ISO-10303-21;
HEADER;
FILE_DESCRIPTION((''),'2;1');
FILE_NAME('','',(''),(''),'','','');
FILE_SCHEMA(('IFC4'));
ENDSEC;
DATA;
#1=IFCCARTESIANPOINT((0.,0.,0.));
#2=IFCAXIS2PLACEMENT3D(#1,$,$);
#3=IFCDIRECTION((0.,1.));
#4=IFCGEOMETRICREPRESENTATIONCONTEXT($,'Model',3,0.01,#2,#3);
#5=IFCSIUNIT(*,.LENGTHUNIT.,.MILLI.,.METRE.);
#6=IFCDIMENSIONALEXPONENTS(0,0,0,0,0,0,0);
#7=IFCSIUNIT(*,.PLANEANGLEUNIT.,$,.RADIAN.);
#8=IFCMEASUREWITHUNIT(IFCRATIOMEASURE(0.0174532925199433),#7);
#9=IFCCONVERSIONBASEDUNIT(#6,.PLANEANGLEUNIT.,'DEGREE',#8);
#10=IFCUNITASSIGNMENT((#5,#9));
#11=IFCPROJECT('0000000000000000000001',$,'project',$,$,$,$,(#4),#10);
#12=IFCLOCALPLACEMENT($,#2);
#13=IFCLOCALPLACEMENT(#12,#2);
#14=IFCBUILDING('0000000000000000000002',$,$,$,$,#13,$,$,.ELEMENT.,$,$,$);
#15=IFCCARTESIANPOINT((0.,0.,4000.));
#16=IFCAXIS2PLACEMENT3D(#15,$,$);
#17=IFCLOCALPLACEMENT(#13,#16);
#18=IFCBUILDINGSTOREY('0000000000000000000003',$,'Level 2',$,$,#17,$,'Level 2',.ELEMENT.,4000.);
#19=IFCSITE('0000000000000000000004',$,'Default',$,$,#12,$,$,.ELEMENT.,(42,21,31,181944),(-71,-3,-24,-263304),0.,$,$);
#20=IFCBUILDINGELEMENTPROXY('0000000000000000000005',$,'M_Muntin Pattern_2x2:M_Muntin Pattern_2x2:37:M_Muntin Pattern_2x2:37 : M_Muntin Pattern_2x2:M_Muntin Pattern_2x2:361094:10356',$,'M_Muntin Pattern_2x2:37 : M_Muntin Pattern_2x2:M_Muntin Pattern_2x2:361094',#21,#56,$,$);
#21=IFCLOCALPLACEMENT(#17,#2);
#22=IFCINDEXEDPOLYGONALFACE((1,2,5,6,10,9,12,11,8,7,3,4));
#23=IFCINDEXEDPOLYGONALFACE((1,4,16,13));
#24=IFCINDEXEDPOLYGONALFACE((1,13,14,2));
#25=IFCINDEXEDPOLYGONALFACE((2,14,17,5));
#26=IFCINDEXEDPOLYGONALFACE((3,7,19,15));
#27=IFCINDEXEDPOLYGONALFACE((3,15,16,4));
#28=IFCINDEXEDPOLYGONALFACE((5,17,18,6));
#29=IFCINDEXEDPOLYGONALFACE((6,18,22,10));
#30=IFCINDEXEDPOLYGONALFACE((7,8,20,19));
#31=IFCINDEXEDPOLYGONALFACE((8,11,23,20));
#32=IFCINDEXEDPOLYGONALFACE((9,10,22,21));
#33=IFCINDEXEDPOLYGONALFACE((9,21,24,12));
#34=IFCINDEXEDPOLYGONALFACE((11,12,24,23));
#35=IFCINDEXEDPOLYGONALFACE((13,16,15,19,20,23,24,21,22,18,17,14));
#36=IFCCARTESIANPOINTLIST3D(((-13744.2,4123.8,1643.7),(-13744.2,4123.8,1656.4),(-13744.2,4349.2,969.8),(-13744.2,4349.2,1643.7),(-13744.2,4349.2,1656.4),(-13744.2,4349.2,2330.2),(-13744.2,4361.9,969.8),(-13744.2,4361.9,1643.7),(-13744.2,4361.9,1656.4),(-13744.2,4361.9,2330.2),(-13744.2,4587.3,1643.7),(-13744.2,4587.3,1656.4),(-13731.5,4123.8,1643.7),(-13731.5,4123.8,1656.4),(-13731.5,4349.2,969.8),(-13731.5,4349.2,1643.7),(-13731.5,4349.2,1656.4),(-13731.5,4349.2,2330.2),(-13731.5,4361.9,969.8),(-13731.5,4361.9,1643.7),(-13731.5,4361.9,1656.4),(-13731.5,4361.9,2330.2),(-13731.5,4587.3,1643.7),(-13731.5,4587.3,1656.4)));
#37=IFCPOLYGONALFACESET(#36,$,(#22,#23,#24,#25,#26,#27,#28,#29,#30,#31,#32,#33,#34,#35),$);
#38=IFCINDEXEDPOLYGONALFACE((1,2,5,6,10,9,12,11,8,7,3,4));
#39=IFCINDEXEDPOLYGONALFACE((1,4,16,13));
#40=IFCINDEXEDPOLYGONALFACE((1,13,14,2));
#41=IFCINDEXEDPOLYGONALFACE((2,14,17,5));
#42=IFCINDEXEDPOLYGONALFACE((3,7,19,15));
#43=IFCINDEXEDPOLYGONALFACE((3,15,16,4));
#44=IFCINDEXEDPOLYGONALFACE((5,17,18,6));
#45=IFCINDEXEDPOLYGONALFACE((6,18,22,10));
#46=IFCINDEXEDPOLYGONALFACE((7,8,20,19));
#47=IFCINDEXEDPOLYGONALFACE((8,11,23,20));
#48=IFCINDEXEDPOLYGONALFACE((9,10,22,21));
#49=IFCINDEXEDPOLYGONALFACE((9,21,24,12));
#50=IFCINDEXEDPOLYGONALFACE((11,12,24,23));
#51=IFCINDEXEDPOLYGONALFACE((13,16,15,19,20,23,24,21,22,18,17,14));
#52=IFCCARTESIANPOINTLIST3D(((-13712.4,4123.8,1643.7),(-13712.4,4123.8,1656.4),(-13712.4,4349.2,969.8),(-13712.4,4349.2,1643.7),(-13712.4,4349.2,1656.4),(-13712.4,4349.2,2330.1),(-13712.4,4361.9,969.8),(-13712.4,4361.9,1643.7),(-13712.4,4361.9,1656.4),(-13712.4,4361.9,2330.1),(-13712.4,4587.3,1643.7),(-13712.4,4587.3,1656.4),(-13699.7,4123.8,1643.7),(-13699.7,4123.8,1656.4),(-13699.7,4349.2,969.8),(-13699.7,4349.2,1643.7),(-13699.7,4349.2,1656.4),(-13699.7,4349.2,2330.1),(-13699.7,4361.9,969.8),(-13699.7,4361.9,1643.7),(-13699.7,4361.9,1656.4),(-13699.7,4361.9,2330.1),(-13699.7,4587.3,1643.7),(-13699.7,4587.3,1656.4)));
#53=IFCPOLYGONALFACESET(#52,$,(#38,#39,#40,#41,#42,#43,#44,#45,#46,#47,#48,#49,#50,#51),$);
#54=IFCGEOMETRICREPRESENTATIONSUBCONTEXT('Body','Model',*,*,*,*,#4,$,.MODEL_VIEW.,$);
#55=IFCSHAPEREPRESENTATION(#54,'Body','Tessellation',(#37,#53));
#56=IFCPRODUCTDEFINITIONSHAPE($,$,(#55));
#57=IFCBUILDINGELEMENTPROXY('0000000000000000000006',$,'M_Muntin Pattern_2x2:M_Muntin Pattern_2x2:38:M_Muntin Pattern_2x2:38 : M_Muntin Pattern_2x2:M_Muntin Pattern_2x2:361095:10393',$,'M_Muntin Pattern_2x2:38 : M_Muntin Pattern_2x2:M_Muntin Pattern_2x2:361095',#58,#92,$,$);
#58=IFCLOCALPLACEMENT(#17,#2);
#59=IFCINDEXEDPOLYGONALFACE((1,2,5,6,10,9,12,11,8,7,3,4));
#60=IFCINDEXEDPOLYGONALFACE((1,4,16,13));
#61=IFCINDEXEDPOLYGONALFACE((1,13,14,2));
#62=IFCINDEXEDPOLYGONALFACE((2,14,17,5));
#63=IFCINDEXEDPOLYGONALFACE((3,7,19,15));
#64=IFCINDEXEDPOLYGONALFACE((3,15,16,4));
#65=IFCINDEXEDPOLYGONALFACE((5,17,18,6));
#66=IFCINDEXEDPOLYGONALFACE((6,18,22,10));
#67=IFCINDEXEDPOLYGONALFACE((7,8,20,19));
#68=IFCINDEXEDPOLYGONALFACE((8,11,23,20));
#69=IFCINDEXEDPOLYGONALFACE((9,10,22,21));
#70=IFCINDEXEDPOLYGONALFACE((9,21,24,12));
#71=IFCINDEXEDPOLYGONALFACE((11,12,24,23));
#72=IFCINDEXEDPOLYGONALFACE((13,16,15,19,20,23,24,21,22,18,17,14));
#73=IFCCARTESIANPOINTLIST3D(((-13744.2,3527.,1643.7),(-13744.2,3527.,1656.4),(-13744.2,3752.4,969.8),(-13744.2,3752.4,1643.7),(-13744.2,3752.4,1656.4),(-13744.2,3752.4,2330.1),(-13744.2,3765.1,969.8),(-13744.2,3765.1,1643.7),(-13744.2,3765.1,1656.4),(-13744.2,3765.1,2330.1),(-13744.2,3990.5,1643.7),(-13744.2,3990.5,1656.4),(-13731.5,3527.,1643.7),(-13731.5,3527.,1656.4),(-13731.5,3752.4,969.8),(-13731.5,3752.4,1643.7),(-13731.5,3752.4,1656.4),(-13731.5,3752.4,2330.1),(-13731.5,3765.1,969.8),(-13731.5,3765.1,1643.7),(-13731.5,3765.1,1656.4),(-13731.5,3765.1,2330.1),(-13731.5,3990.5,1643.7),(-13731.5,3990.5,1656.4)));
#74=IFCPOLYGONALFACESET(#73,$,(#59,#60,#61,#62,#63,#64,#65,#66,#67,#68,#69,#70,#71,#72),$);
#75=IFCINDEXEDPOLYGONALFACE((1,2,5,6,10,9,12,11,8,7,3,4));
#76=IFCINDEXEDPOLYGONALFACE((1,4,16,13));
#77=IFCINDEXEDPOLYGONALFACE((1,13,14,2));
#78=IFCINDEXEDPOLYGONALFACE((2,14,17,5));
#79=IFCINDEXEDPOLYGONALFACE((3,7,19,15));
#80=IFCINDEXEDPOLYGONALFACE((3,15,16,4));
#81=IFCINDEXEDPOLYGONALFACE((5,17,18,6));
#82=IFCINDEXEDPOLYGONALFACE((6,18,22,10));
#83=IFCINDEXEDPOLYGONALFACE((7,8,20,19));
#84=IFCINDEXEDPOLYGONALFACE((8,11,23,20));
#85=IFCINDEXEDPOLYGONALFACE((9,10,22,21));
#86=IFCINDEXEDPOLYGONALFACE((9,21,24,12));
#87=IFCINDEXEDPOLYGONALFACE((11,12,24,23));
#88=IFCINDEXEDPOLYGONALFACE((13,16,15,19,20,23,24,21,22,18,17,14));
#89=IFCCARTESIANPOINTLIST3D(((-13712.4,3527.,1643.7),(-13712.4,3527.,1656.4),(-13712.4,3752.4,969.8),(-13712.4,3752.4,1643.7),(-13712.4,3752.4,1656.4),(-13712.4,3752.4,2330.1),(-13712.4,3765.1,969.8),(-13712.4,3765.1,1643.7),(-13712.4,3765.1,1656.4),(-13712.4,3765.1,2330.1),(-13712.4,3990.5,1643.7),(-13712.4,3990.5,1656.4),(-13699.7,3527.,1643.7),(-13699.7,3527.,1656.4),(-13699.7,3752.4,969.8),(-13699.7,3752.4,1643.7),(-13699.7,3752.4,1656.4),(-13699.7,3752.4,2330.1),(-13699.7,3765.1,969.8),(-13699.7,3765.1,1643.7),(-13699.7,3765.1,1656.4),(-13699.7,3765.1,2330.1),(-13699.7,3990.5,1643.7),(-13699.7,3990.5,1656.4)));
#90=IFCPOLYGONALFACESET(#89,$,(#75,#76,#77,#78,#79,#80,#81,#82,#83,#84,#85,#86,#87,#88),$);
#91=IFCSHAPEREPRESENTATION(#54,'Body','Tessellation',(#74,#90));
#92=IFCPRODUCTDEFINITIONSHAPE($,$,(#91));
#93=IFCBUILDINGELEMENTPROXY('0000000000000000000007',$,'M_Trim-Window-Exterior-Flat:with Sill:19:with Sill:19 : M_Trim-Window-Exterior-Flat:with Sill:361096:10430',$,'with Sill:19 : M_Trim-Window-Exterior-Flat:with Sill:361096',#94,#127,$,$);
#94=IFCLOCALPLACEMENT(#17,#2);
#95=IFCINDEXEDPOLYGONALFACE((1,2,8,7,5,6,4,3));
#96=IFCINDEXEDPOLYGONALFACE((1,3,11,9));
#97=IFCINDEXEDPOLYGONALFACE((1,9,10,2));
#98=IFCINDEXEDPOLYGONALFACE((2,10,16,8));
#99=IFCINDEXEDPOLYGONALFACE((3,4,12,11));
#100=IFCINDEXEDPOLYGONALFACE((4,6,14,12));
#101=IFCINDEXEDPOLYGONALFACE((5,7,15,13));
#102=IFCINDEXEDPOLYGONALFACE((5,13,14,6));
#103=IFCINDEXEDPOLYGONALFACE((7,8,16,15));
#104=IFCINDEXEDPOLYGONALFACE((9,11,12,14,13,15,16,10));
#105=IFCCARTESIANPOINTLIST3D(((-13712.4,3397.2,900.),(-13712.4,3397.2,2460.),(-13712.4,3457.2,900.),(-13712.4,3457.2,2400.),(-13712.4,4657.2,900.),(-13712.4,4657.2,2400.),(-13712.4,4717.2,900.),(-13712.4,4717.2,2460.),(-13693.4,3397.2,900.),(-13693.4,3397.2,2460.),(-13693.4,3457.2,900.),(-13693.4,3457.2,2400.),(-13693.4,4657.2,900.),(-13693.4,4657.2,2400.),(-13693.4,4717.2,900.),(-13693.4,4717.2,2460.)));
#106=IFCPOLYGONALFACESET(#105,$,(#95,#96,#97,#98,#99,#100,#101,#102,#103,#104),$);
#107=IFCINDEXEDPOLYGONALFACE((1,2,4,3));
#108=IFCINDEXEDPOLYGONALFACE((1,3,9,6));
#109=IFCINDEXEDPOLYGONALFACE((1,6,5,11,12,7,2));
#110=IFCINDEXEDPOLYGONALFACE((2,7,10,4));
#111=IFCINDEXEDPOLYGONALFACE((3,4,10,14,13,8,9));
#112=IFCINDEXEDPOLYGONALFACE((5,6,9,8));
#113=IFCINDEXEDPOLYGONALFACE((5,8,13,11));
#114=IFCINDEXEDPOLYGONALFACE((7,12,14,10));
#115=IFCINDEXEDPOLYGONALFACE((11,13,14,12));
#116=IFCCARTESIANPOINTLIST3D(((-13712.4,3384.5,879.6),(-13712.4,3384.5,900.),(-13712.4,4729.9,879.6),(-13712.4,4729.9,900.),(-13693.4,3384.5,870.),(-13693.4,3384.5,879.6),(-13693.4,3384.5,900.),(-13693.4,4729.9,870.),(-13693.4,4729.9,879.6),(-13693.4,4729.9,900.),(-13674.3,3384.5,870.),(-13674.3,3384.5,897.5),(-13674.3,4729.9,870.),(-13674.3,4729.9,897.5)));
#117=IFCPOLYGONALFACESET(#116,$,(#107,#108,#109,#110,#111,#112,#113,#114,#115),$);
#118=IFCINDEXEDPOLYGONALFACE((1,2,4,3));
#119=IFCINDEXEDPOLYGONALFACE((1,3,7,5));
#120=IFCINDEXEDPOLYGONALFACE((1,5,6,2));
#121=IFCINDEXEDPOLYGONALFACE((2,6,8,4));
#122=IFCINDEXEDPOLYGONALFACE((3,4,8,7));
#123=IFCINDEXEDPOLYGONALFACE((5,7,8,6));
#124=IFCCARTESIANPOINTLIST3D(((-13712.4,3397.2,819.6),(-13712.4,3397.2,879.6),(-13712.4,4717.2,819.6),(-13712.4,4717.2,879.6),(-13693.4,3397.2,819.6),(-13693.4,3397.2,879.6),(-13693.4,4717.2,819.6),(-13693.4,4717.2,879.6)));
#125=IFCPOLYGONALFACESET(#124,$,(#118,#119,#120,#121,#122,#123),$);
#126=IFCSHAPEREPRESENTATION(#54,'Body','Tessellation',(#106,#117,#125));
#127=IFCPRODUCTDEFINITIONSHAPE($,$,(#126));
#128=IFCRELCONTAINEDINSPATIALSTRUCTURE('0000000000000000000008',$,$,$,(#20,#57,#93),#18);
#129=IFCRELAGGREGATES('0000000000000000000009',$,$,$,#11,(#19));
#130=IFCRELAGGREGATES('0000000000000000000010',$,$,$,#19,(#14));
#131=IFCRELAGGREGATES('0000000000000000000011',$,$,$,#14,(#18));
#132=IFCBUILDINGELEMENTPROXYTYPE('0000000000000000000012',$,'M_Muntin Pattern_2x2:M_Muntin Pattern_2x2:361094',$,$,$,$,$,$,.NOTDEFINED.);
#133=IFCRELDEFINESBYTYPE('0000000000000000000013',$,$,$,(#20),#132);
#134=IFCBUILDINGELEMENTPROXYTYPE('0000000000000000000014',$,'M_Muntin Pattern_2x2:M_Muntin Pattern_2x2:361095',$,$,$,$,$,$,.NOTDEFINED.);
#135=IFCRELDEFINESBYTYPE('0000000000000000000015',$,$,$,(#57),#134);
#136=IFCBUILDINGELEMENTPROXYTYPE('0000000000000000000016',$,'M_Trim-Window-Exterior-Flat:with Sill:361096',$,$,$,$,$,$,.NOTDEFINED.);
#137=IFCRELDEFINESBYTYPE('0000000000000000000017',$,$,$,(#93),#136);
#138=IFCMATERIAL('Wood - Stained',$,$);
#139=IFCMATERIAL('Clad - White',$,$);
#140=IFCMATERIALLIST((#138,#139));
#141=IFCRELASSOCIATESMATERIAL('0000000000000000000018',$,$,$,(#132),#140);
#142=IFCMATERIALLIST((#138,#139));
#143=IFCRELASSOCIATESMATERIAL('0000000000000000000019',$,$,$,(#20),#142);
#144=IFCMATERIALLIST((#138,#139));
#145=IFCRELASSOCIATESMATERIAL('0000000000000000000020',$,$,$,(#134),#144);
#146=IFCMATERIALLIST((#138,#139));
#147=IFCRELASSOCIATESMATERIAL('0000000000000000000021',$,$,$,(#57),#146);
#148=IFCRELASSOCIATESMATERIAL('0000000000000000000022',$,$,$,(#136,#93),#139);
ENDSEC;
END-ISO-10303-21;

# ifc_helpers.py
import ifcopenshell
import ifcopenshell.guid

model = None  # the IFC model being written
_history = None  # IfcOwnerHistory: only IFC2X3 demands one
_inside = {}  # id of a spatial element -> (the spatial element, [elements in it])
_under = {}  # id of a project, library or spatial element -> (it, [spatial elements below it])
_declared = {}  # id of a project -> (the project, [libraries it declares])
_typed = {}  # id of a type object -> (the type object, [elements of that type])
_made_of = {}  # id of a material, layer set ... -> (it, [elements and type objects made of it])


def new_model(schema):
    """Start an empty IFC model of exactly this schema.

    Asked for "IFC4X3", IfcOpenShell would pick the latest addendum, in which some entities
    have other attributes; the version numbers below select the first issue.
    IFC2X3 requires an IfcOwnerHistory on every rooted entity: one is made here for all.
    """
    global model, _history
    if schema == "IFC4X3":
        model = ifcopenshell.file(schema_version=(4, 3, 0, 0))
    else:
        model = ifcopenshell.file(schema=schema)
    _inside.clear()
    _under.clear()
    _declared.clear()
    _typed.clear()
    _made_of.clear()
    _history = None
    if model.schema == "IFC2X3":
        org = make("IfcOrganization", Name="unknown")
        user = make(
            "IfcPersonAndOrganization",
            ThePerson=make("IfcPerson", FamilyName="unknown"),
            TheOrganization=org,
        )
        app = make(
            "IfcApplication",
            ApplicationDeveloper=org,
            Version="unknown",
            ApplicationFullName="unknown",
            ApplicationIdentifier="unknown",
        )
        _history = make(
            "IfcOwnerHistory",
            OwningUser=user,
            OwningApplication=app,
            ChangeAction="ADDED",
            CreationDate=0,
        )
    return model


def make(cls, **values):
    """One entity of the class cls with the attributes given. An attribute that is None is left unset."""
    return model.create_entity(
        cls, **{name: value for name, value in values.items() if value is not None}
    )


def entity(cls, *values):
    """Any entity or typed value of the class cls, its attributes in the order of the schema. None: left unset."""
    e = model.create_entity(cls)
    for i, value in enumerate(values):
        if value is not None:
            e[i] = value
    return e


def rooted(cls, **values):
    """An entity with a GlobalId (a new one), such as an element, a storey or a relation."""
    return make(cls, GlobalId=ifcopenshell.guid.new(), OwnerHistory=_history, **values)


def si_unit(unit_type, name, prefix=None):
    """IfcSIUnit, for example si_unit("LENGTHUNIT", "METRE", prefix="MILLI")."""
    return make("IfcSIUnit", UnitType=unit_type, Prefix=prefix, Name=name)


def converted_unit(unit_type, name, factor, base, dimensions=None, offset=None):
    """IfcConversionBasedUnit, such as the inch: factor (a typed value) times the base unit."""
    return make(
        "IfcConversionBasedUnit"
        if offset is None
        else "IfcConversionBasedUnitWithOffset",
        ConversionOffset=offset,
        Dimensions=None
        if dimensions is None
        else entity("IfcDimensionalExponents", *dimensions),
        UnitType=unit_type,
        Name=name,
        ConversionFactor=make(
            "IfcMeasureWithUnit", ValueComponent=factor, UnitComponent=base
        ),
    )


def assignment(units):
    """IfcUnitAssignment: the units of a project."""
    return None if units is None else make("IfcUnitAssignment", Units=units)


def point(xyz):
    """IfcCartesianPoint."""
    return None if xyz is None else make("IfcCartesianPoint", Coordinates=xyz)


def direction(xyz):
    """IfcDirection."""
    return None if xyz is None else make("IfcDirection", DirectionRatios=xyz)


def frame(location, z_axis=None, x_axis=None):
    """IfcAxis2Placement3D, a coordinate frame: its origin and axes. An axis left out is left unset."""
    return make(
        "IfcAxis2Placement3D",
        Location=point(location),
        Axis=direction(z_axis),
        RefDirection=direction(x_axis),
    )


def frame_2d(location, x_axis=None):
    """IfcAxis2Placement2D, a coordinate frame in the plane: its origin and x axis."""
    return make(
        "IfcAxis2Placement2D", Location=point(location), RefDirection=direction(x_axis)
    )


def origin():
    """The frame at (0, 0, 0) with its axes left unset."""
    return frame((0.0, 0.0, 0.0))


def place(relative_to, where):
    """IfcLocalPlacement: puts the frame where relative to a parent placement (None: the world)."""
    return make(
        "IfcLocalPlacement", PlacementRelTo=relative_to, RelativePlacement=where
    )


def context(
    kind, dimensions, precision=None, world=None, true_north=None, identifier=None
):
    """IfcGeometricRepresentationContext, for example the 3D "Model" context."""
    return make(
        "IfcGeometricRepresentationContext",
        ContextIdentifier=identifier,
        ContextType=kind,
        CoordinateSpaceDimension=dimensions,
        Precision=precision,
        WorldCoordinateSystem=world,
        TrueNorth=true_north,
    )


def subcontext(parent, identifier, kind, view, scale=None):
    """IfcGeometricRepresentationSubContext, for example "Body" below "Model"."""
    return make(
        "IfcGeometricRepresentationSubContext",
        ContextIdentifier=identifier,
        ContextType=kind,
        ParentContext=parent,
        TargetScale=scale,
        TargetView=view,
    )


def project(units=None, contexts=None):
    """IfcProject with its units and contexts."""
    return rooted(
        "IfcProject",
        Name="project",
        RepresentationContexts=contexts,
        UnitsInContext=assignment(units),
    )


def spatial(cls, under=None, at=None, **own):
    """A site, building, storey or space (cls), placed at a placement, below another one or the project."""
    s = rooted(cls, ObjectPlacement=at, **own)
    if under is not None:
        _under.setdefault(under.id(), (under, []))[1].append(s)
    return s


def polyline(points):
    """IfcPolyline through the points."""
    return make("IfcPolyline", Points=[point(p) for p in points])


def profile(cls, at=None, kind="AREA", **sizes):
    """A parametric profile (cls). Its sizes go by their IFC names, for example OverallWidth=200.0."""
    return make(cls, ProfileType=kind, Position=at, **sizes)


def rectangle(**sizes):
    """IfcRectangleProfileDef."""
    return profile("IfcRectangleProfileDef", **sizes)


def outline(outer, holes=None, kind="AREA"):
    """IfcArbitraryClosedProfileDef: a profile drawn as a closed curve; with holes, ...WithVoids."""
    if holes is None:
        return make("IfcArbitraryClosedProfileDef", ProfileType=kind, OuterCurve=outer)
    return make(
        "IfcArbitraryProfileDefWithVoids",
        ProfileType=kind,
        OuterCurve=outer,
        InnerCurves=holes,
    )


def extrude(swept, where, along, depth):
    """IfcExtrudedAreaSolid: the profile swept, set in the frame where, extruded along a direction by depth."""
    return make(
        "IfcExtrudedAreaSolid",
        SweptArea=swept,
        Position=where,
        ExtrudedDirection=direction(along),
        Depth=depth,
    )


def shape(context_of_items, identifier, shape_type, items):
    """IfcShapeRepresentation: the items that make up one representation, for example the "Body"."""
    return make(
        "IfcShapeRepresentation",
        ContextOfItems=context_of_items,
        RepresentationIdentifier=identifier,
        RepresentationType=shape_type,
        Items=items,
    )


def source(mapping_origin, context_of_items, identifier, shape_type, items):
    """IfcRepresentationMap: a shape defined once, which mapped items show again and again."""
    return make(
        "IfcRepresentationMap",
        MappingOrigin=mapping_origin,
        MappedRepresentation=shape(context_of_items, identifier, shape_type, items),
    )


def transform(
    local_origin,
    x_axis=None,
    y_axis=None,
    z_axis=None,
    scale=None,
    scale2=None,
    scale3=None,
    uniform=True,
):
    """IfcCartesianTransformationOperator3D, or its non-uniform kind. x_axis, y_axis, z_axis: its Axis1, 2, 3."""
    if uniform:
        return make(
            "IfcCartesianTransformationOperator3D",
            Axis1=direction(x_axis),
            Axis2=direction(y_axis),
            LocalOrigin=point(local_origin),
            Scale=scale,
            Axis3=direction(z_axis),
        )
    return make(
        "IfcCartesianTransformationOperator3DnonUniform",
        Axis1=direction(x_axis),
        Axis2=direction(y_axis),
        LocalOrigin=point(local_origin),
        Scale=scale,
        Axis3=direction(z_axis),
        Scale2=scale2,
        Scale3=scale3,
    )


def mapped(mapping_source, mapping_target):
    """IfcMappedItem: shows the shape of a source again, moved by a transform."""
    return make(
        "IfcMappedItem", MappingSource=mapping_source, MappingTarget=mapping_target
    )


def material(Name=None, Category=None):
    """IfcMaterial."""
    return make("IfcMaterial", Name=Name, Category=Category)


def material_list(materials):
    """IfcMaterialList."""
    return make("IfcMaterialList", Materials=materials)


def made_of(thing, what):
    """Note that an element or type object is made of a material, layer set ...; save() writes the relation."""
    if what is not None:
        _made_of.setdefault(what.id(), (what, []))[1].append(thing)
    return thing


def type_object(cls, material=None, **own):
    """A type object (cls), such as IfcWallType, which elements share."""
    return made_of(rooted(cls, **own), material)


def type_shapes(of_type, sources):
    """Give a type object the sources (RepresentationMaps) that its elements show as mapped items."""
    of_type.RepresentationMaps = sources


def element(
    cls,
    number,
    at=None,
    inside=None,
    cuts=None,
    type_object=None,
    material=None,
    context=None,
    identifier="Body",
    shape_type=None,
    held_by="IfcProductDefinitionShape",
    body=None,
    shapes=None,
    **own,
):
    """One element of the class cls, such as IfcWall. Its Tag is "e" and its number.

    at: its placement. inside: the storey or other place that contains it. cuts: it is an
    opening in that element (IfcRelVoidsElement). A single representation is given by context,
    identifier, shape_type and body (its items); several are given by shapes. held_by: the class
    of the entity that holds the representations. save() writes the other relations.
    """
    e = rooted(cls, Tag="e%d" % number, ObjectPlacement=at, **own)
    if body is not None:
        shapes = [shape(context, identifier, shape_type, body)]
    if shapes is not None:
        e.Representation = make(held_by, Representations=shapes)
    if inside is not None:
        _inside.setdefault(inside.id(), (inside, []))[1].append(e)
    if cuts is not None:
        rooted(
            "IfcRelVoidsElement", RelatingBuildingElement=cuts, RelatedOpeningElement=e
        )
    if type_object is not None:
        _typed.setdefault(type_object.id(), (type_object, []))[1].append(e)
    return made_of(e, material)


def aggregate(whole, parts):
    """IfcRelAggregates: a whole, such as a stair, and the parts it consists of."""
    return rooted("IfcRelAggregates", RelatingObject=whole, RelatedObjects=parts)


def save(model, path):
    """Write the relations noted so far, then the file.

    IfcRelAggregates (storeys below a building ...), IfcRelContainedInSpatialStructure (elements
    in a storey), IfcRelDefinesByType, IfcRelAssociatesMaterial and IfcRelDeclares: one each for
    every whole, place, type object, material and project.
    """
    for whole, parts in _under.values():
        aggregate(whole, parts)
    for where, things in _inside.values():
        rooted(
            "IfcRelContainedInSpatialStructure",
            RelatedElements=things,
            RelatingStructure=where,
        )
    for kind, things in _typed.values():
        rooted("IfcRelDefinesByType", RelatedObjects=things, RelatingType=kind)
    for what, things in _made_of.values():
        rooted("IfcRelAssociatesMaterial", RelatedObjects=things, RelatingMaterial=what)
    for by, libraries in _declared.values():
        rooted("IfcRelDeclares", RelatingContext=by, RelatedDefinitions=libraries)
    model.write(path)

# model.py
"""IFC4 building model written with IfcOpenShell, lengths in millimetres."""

from ifc_helpers import new_model, entity, si_unit, converted_unit, direction, frame, frame_2d, origin, place, context, subcontext, project, spatial, polyline, rectangle, outline, extrude, source, transform, mapped, material, material_list, type_object, type_shapes, element, save


model = new_model("IFC4")

# Units and contexts
model_context = context("Model", 3, precision=0.01, world=origin(), true_north=direction((0.0, 1.0)))
body_context = subcontext(model_context, "Body", "Model", "MODEL_VIEW")
ifc_project = project(units=[si_unit("LENGTHUNIT", "METRE", prefix="MILLI"), converted_unit("PLANEANGLEUNIT", "DEGREE", entity("IfcRatioMeasure", 0.0174532925199433), si_unit("PLANEANGLEUNIT", "RADIAN"), dimensions=[0, 0, 0, 0, 0, 0, 0])], contexts=[model_context])

# Site, building, storey
site_placement = place(None, origin())
site = spatial("IfcSite", under=ifc_project, at=site_placement, Name="Default", CompositionType="ELEMENT", RefLatitude=(42, 21, 31, 181944), RefLongitude=(-71, -3, -24, -263304), RefElevation=0.0)
building_placement = place(site_placement, origin())
building = spatial("IfcBuilding", under=site, at=building_placement, CompositionType="ELEMENT")
storey_placement = place(building_placement, frame((0.0, 0.0, 4000.0)))
storey = spatial("IfcBuildingStorey", under=building, at=storey_placement, Name="Level 2", LongName="Level 2", CompositionType="ELEMENT", Elevation=4000.0)

# Building element proxies
ifc_material_1 = material(Name="Wood - Stained")
ifc_material_2 = material(Name="Clad - White")
ifc_material_list_1 = material_list([ifc_material_1, ifc_material_2])
ifc_material_list_2 = material_list([ifc_material_1, ifc_material_2])
building_element_proxy_type_1 = type_object("IfcBuildingElementProxyType", Name="M_Muntin Pattern_2x2:M_Muntin Pattern_2x2:361094", PredefinedType="NOTDEFINED", material=ifc_material_list_2)
shared_shape_1 = source(origin(), body_context, "Body", "SweptSolid", [
    extrude(outline(polyline([(-6.4, -680.2), (6.3, -680.2), (6.3, -6.4), (231.7, -6.4), (231.7, 6.3), (6.3, 6.3), (6.3, 680.2), (-6.4, 680.2), (-6.4, 6.3), (-231.7, 6.3), (-231.7, -6.4), (-6.4, -6.4), (-6.4, -680.2)])), frame((-13744.2, 4355.6, 5650.0), z_axis=(1.0, 0.0, 0.0), x_axis=(0.0, -1.0, 0.0)), (0.0, 0.0, 1.0), 12.7),
    extrude(outline(polyline([(-6.4, -680.1), (6.3, -680.1), (6.3, -6.4), (231.7, -6.4), (231.7, 6.3), (6.3, 6.3), (6.3, 680.2), (-6.4, 680.2), (-6.4, 6.3), (-231.7, 6.3), (-231.7, -6.4), (-6.4, -6.4), (-6.4, -680.1)])), frame((-13712.4, 4355.6, 5650.0), z_axis=(1.0, 0.0, 0.0), x_axis=(0.0, -1.0, 0.0)), (0.0, 0.0, 1.0), 12.7),
])
type_shapes(building_element_proxy_type_1, [shared_shape_1])
proxy_1_placement = place(storey_placement, frame((0.0, 0.0, -4000.0)))
element("IfcBuildingElementProxy", 1, at=proxy_1_placement, inside=storey, type_object=building_element_proxy_type_1, material=ifc_material_list_1, Name="M_Muntin Pattern_2x2:M_Muntin Pattern_2x2:37:M_Muntin Pattern_2x2:37 : M_Muntin Pattern_2x2:M_Muntin Pattern_2x2:361094:10356", ObjectType="M_Muntin Pattern_2x2:37 : M_Muntin Pattern_2x2:M_Muntin Pattern_2x2:361094", context=body_context, shape_type="MappedRepresentation", body=[
    mapped(shared_shape_1, transform((0.0, 0.0, 0.0), scale=1.0)),
])
ifc_material_list_3 = material_list([ifc_material_1, ifc_material_2])
ifc_material_list_4 = material_list([ifc_material_1, ifc_material_2])
building_element_proxy_type_2 = type_object("IfcBuildingElementProxyType", Name="M_Muntin Pattern_2x2:M_Muntin Pattern_2x2:361095", PredefinedType="NOTDEFINED", material=ifc_material_list_4)
shared_shape_2 = source(origin(), body_context, "Body", "SweptSolid", [
    extrude(outline(polyline([(-680.1, 6.4), (-680.1, -6.3), (-6.4, -6.3), (-6.4, -231.7), (6.3, -231.7), (6.3, -6.3), (680.2, -6.3), (680.2, 6.4), (6.3, 6.4), (6.3, 231.7), (-6.4, 231.7), (-6.4, 6.4), (-680.1, 6.4)])), frame((-13744.2, 3758.7, 5650.0), z_axis=(-1.0, 0.0, 0.0), x_axis=(0.0, 0.0, -1.0)), (0.0, 0.0, -1.0), 12.7),
    extrude(outline(polyline([(-680.1, 6.4), (-680.1, -6.3), (-6.4, -6.3), (-6.4, -231.7), (6.3, -231.7), (6.3, -6.3), (680.2, -6.3), (680.2, 6.4), (6.3, 6.4), (6.3, 231.7), (-6.4, 231.7), (-6.4, 6.4), (-680.1, 6.4)])), frame((-13712.4, 3758.7, 5650.0), z_axis=(-1.0, 0.0, 0.0), x_axis=(0.0, 0.0, -1.0)), (0.0, 0.0, -1.0), 12.7),
])
type_shapes(building_element_proxy_type_2, [shared_shape_2])
proxy_2_placement = place(storey_placement, frame((0.0, 0.0, -4000.0)))
element("IfcBuildingElementProxy", 2, at=proxy_2_placement, inside=storey, type_object=building_element_proxy_type_2, material=ifc_material_list_3, Name="M_Muntin Pattern_2x2:M_Muntin Pattern_2x2:38:M_Muntin Pattern_2x2:38 : M_Muntin Pattern_2x2:M_Muntin Pattern_2x2:361095:10393", ObjectType="M_Muntin Pattern_2x2:38 : M_Muntin Pattern_2x2:M_Muntin Pattern_2x2:361095", context=body_context, shape_type="MappedRepresentation", body=[
    mapped(shared_shape_2, transform((0.0, 0.0, 0.0), scale=1.0)),
])
building_element_proxy_type_3 = type_object("IfcBuildingElementProxyType", Name="M_Trim-Window-Exterior-Flat:with Sill:361096", PredefinedType="NOTDEFINED", material=ifc_material_2)
shared_shape_3 = source(origin(), body_context, "Body", "SweptSolid", [
    extrude(outline(polyline([(-660.0, -765.0), (-600.0, -765.0), (-600.0, 735.0), (600.0, 735.0), (600.0, -765.0), (660.0, -765.0), (660.0, 795.0), (-660.0, 795.0), (-660.0, -765.0)])), frame((-13712.4, 4057.2, 5665.0), z_axis=(1.0, 0.0, 0.0), x_axis=(0.0, 1.0, 0.0)), (0.0, 0.0, 1.0), 19.1),
    extrude(outline(polyline([(-15.2, 0.0), (-15.2, -19.0), (12.3, -19.0), (14.8, 0.0), (14.8, 19.0), (-5.7, 19.0), (-5.7, 0.0), (-15.2, 0.0)])), frame((-13693.4, 3384.5, 4885.2), z_axis=(0.0, -1.0, 0.0), x_axis=(0.0, 0.0, 1.0)), (0.0, 0.0, -1.0), 1345.4),
    extrude(rectangle(XDim=19.1, YDim=1320.0, at=frame_2d((0.0, 0.0), x_axis=(1.0, 0.0))), frame((-13702.9, 4057.2, 4819.6), z_axis=(0.0, 0.0, 1.0), x_axis=(-1.0, 0.0, 0.0)), (0.0, 0.0, 1.0), 60.0),
])
type_shapes(building_element_proxy_type_3, [shared_shape_3])
proxy_3_placement = place(storey_placement, frame((0.0, 0.0, -4000.0)))
element("IfcBuildingElementProxy", 3, at=proxy_3_placement, inside=storey, type_object=building_element_proxy_type_3, material=ifc_material_2, Name="M_Trim-Window-Exterior-Flat:with Sill:19:with Sill:19 : M_Trim-Window-Exterior-Flat:with Sill:361096:10430", ObjectType="with Sill:19 : M_Trim-Window-Exterior-Flat:with Sill:361096", context=body_context, shape_type="MappedRepresentation", body=[
    mapped(shared_shape_3, transform((0.0, 0.0, 0.0), scale=1.0)),
])

save(model, "model.ifc")
